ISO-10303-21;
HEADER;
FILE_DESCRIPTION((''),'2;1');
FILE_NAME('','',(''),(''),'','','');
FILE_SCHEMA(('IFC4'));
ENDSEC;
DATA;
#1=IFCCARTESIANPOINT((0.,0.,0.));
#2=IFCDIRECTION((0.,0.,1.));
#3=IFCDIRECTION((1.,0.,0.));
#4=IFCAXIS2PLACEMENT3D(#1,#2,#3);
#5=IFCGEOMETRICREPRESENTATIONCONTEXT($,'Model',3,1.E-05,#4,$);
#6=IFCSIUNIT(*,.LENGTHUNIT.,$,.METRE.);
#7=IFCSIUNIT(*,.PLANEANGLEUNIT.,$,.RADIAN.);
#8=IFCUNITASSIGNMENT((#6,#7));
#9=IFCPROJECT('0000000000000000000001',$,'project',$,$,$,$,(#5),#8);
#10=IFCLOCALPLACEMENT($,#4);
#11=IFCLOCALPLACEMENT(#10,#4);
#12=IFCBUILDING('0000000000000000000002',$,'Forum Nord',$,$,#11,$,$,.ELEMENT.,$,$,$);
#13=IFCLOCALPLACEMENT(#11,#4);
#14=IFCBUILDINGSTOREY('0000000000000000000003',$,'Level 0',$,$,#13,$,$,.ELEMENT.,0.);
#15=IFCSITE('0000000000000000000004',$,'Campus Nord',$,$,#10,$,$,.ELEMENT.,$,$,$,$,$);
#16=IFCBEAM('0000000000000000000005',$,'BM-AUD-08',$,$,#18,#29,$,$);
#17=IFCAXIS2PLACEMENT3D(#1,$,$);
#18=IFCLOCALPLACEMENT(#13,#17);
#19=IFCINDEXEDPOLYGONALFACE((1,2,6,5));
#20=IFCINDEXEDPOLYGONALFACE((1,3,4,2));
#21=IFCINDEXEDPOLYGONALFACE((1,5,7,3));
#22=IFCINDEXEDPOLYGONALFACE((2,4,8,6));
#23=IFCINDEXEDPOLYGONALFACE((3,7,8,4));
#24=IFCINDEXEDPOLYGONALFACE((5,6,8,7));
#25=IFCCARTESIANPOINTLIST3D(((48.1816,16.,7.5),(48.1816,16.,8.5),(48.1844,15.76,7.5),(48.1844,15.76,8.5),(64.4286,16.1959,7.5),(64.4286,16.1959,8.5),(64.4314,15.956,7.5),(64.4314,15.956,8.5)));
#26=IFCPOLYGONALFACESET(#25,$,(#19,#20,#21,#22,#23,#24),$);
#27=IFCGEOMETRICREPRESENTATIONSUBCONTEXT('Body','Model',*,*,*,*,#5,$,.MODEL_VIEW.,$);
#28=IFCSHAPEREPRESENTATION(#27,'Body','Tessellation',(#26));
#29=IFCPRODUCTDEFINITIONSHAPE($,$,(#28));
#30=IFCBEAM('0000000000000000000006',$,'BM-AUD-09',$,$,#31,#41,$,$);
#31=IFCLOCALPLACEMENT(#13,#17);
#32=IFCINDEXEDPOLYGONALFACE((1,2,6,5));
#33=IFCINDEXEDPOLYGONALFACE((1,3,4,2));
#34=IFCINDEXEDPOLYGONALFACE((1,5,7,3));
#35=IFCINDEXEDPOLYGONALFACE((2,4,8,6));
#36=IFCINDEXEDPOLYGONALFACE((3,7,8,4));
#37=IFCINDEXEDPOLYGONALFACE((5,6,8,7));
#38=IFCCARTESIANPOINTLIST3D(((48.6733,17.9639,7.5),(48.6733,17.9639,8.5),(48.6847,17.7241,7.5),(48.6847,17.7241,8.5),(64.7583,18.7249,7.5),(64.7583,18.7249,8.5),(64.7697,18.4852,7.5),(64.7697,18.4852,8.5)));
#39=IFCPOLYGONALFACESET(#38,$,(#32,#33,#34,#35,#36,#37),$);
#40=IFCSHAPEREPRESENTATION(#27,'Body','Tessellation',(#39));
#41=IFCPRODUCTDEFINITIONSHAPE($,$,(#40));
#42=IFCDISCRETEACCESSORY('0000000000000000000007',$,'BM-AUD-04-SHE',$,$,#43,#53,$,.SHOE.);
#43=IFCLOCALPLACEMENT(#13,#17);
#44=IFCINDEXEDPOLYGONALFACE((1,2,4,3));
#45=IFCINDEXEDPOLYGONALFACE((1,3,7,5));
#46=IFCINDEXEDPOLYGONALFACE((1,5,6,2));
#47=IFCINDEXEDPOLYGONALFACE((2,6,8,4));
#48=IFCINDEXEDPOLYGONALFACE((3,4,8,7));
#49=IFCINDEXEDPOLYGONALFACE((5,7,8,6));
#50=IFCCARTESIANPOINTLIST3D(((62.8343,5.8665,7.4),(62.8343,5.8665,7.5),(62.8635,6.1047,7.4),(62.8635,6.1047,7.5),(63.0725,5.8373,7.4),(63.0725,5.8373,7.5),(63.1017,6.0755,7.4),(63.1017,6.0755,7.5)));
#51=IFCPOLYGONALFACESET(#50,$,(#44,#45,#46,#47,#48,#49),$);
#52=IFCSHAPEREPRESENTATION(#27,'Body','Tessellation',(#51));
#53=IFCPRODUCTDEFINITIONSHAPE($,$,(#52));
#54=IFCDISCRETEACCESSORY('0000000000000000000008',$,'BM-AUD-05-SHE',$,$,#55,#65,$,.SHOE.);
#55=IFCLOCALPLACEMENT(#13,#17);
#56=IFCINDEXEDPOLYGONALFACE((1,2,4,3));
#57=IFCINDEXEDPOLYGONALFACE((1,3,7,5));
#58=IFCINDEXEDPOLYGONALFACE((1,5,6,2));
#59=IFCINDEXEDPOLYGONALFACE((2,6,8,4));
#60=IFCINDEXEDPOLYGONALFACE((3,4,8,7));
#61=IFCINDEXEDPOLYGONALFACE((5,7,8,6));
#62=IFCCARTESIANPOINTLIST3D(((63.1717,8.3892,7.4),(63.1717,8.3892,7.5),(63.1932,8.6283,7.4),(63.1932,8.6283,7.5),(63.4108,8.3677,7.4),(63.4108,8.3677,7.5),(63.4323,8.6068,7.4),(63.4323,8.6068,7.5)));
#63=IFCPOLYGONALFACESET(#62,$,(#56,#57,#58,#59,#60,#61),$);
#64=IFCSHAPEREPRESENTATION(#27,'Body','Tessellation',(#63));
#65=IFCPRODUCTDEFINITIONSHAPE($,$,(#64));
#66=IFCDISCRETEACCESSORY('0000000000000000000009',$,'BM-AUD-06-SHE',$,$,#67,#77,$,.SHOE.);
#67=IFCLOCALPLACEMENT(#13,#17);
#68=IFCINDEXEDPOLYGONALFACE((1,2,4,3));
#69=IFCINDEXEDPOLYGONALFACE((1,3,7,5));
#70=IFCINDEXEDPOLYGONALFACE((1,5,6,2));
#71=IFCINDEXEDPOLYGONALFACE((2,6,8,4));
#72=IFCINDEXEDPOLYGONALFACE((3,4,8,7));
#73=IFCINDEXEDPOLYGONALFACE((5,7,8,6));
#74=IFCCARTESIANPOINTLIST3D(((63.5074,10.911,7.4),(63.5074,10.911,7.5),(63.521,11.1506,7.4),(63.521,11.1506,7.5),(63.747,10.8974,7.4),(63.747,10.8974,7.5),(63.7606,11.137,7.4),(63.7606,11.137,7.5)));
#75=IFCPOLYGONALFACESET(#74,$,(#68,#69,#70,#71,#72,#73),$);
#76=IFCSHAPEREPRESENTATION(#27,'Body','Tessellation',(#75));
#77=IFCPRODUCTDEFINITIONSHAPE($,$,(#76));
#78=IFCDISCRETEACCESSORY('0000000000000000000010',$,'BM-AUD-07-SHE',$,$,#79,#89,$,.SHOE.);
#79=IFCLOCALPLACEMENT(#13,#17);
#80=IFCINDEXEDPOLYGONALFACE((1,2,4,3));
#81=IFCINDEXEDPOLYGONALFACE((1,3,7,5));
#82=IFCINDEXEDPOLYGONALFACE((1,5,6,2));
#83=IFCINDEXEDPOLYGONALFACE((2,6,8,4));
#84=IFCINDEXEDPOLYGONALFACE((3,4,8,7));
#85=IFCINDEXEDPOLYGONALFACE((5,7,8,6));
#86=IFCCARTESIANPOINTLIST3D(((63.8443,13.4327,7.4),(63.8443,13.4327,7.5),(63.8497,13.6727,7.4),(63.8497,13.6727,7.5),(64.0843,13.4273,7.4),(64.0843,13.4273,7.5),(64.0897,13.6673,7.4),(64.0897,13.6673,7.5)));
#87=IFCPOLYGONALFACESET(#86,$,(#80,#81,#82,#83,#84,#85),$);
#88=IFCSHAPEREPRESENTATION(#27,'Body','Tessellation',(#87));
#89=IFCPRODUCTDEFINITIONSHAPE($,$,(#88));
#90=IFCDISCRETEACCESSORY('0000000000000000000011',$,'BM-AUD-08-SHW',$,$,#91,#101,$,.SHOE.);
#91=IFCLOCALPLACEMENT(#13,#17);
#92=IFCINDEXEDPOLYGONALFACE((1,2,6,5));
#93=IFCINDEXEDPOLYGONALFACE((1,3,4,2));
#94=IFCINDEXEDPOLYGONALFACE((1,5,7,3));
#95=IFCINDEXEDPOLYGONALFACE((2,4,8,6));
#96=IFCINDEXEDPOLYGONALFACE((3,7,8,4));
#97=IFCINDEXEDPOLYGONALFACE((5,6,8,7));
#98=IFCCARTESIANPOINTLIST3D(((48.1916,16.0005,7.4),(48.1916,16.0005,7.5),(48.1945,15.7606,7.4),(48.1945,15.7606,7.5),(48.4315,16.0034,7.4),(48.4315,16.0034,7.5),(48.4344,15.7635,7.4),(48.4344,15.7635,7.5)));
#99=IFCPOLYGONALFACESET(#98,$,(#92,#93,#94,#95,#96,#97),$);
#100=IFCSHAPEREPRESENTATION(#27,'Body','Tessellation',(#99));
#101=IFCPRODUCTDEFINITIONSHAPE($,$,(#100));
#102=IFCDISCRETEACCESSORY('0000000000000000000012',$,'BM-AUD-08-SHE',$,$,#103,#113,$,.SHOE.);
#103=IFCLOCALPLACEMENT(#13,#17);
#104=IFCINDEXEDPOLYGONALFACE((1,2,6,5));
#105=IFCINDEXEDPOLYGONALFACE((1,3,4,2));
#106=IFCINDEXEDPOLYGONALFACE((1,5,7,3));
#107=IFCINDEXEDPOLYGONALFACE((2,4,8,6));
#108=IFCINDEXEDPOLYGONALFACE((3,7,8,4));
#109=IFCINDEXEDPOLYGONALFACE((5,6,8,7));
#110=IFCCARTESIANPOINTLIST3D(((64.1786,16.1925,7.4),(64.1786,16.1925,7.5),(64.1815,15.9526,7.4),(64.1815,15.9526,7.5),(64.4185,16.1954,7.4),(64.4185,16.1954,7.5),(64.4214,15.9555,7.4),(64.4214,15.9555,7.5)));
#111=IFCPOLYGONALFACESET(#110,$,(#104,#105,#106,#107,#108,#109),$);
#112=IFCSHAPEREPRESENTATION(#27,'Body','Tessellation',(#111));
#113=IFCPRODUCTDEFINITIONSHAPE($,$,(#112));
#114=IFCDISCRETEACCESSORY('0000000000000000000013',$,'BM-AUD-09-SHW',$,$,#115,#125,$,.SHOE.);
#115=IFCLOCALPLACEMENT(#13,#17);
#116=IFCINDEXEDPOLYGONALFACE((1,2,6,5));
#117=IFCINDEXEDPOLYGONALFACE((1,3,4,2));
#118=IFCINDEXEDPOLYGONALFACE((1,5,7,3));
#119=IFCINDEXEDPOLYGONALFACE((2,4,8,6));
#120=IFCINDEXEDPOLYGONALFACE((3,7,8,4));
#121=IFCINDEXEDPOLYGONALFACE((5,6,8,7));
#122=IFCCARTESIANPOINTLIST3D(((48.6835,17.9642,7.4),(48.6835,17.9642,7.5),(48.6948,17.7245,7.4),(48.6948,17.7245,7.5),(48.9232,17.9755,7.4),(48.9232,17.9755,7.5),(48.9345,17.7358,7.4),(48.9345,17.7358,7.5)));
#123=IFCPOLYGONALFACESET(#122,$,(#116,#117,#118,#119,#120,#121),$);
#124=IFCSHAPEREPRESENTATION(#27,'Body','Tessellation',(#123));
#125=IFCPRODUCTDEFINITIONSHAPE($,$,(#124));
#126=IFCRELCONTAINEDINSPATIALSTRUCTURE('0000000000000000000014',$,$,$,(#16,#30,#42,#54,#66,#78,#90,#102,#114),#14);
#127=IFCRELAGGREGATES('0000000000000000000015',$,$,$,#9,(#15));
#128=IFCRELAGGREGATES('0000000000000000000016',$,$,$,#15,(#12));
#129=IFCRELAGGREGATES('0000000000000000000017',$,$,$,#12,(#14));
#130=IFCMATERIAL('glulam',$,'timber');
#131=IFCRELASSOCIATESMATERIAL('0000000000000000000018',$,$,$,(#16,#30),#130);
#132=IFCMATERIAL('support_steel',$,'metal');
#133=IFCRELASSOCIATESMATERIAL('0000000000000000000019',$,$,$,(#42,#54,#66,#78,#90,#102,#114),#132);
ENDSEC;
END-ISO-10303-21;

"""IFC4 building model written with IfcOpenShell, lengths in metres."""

from ifc_helpers import new_model, si_unit, frame, origin_with_axes, origin_2d_with_axis, place, context, subcontext, project, spatial, rectangle, extrude, material, element, save


model = new_model("IFC4")

# Units and contexts
model_context = context("Model", 3, precision=1e-05, world=origin_with_axes())
body_context = subcontext(model_context, "Body", "Model", "MODEL_VIEW")
ifc_project = project(units=[si_unit("LENGTHUNIT", "METRE"), si_unit("PLANEANGLEUNIT", "RADIAN")], contexts=[model_context])

# Site, building, storey
site_placement = place(None, origin_with_axes())
site = spatial("IfcSite", under=ifc_project, at=site_placement, Name="Campus Nord", CompositionType="ELEMENT")
building_placement = place(site_placement, origin_with_axes())
building = spatial("IfcBuilding", under=site, at=building_placement, Name="Forum Nord", CompositionType="ELEMENT")
storey_placement = place(building_placement, origin_with_axes())
storey = spatial("IfcBuildingStorey", under=building, at=storey_placement, Name="Level 0", CompositionType="ELEMENT", Elevation=0.0)

# Beams
ifc_material_1 = material(Name="glulam", Category="timber")
beam_1_placement = place(storey_placement, frame((48.183, 15.88, 8.0), z_axis=(0.99993, 0.01206, 0.0), x_axis=(-0.01206, 0.99993, 0.0)))
element("IfcBeam", 1, at=beam_1_placement, inside=storey, material=ifc_material_1, Name="BM-AUD-08", context=body_context, shape_type="SweptSolid", body=[
    extrude(rectangle(XDim=0.24, YDim=1.0, at=origin_2d_with_axis()), origin_with_axes(), (0.0, 0.0, 1.0), 16.2482),
])
beam_2_placement = place(storey_placement, frame((48.679, 17.844, 8.0), z_axis=(0.99888, 0.04726, 0.0), x_axis=(-0.04726, 0.99888, 0.0)))
element("IfcBeam", 2, at=beam_2_placement, inside=storey, material=ifc_material_1, Name="BM-AUD-09", context=body_context, shape_type="SweptSolid", body=[
    extrude(rectangle(XDim=0.24, YDim=1.0, at=origin_2d_with_axis()), origin_with_axes(), (0.0, 0.0, 1.0), 16.103),
])

# Discrete accessories
ifc_material_2 = material(Name="support_steel", Category="metal")
for number, where, z_axis, x_axis, name in (
    (3, (62.968, 5.971, 7.4), (0.0, 0.0, 1.0), (0.99255, -0.12187, 0.0), "BM-AUD-04-SHE"),
    (4, (63.302, 8.498, 7.4), (0.0, 0.0, 1.0), (0.99598, -0.08959, 0.0), "BM-AUD-05-SHE"),
    (5, (63.634, 11.024, 7.4), (0.0, 0.0, 1.0), (0.9984, -0.05652, 0.0), "BM-AUD-06-SHE"),
    (6, (63.967, 13.55, 7.4), (0.0, 0.0, 1.0), (0.99975, -0.02251, 0.0), "BM-AUD-07-SHE"),
    (7, (48.313, 15.882, 7.4), (0.0, 0.0, 1.0), (0.99993, 0.01204, 0.0), "BM-AUD-08-SHW"),
    (8, (64.3, 16.074, 7.4), (0.0, 0.0, 1.0), (0.99993, 0.01204, 0.0), "BM-AUD-08-SHE"),
    (9, (48.809, 17.85, 7.4), (0.0, 0.0, 1.0), (0.99888, 0.04728, 0.0), "BM-AUD-09-SHW"),
):
    element("IfcDiscreteAccessory", number, at=place(storey_placement, frame(where, z_axis=z_axis, x_axis=x_axis)), inside=storey, material=ifc_material_2, Name=name, PredefinedType="SHOE", context=body_context, shape_type="SweptSolid", body=[
        extrude(rectangle(XDim=0.24, YDim=0.24, at=origin_2d_with_axis()), origin_with_axes(), (0.0, 0.0, 1.0), 0.1),
    ])

save(model, "model.ifc")
